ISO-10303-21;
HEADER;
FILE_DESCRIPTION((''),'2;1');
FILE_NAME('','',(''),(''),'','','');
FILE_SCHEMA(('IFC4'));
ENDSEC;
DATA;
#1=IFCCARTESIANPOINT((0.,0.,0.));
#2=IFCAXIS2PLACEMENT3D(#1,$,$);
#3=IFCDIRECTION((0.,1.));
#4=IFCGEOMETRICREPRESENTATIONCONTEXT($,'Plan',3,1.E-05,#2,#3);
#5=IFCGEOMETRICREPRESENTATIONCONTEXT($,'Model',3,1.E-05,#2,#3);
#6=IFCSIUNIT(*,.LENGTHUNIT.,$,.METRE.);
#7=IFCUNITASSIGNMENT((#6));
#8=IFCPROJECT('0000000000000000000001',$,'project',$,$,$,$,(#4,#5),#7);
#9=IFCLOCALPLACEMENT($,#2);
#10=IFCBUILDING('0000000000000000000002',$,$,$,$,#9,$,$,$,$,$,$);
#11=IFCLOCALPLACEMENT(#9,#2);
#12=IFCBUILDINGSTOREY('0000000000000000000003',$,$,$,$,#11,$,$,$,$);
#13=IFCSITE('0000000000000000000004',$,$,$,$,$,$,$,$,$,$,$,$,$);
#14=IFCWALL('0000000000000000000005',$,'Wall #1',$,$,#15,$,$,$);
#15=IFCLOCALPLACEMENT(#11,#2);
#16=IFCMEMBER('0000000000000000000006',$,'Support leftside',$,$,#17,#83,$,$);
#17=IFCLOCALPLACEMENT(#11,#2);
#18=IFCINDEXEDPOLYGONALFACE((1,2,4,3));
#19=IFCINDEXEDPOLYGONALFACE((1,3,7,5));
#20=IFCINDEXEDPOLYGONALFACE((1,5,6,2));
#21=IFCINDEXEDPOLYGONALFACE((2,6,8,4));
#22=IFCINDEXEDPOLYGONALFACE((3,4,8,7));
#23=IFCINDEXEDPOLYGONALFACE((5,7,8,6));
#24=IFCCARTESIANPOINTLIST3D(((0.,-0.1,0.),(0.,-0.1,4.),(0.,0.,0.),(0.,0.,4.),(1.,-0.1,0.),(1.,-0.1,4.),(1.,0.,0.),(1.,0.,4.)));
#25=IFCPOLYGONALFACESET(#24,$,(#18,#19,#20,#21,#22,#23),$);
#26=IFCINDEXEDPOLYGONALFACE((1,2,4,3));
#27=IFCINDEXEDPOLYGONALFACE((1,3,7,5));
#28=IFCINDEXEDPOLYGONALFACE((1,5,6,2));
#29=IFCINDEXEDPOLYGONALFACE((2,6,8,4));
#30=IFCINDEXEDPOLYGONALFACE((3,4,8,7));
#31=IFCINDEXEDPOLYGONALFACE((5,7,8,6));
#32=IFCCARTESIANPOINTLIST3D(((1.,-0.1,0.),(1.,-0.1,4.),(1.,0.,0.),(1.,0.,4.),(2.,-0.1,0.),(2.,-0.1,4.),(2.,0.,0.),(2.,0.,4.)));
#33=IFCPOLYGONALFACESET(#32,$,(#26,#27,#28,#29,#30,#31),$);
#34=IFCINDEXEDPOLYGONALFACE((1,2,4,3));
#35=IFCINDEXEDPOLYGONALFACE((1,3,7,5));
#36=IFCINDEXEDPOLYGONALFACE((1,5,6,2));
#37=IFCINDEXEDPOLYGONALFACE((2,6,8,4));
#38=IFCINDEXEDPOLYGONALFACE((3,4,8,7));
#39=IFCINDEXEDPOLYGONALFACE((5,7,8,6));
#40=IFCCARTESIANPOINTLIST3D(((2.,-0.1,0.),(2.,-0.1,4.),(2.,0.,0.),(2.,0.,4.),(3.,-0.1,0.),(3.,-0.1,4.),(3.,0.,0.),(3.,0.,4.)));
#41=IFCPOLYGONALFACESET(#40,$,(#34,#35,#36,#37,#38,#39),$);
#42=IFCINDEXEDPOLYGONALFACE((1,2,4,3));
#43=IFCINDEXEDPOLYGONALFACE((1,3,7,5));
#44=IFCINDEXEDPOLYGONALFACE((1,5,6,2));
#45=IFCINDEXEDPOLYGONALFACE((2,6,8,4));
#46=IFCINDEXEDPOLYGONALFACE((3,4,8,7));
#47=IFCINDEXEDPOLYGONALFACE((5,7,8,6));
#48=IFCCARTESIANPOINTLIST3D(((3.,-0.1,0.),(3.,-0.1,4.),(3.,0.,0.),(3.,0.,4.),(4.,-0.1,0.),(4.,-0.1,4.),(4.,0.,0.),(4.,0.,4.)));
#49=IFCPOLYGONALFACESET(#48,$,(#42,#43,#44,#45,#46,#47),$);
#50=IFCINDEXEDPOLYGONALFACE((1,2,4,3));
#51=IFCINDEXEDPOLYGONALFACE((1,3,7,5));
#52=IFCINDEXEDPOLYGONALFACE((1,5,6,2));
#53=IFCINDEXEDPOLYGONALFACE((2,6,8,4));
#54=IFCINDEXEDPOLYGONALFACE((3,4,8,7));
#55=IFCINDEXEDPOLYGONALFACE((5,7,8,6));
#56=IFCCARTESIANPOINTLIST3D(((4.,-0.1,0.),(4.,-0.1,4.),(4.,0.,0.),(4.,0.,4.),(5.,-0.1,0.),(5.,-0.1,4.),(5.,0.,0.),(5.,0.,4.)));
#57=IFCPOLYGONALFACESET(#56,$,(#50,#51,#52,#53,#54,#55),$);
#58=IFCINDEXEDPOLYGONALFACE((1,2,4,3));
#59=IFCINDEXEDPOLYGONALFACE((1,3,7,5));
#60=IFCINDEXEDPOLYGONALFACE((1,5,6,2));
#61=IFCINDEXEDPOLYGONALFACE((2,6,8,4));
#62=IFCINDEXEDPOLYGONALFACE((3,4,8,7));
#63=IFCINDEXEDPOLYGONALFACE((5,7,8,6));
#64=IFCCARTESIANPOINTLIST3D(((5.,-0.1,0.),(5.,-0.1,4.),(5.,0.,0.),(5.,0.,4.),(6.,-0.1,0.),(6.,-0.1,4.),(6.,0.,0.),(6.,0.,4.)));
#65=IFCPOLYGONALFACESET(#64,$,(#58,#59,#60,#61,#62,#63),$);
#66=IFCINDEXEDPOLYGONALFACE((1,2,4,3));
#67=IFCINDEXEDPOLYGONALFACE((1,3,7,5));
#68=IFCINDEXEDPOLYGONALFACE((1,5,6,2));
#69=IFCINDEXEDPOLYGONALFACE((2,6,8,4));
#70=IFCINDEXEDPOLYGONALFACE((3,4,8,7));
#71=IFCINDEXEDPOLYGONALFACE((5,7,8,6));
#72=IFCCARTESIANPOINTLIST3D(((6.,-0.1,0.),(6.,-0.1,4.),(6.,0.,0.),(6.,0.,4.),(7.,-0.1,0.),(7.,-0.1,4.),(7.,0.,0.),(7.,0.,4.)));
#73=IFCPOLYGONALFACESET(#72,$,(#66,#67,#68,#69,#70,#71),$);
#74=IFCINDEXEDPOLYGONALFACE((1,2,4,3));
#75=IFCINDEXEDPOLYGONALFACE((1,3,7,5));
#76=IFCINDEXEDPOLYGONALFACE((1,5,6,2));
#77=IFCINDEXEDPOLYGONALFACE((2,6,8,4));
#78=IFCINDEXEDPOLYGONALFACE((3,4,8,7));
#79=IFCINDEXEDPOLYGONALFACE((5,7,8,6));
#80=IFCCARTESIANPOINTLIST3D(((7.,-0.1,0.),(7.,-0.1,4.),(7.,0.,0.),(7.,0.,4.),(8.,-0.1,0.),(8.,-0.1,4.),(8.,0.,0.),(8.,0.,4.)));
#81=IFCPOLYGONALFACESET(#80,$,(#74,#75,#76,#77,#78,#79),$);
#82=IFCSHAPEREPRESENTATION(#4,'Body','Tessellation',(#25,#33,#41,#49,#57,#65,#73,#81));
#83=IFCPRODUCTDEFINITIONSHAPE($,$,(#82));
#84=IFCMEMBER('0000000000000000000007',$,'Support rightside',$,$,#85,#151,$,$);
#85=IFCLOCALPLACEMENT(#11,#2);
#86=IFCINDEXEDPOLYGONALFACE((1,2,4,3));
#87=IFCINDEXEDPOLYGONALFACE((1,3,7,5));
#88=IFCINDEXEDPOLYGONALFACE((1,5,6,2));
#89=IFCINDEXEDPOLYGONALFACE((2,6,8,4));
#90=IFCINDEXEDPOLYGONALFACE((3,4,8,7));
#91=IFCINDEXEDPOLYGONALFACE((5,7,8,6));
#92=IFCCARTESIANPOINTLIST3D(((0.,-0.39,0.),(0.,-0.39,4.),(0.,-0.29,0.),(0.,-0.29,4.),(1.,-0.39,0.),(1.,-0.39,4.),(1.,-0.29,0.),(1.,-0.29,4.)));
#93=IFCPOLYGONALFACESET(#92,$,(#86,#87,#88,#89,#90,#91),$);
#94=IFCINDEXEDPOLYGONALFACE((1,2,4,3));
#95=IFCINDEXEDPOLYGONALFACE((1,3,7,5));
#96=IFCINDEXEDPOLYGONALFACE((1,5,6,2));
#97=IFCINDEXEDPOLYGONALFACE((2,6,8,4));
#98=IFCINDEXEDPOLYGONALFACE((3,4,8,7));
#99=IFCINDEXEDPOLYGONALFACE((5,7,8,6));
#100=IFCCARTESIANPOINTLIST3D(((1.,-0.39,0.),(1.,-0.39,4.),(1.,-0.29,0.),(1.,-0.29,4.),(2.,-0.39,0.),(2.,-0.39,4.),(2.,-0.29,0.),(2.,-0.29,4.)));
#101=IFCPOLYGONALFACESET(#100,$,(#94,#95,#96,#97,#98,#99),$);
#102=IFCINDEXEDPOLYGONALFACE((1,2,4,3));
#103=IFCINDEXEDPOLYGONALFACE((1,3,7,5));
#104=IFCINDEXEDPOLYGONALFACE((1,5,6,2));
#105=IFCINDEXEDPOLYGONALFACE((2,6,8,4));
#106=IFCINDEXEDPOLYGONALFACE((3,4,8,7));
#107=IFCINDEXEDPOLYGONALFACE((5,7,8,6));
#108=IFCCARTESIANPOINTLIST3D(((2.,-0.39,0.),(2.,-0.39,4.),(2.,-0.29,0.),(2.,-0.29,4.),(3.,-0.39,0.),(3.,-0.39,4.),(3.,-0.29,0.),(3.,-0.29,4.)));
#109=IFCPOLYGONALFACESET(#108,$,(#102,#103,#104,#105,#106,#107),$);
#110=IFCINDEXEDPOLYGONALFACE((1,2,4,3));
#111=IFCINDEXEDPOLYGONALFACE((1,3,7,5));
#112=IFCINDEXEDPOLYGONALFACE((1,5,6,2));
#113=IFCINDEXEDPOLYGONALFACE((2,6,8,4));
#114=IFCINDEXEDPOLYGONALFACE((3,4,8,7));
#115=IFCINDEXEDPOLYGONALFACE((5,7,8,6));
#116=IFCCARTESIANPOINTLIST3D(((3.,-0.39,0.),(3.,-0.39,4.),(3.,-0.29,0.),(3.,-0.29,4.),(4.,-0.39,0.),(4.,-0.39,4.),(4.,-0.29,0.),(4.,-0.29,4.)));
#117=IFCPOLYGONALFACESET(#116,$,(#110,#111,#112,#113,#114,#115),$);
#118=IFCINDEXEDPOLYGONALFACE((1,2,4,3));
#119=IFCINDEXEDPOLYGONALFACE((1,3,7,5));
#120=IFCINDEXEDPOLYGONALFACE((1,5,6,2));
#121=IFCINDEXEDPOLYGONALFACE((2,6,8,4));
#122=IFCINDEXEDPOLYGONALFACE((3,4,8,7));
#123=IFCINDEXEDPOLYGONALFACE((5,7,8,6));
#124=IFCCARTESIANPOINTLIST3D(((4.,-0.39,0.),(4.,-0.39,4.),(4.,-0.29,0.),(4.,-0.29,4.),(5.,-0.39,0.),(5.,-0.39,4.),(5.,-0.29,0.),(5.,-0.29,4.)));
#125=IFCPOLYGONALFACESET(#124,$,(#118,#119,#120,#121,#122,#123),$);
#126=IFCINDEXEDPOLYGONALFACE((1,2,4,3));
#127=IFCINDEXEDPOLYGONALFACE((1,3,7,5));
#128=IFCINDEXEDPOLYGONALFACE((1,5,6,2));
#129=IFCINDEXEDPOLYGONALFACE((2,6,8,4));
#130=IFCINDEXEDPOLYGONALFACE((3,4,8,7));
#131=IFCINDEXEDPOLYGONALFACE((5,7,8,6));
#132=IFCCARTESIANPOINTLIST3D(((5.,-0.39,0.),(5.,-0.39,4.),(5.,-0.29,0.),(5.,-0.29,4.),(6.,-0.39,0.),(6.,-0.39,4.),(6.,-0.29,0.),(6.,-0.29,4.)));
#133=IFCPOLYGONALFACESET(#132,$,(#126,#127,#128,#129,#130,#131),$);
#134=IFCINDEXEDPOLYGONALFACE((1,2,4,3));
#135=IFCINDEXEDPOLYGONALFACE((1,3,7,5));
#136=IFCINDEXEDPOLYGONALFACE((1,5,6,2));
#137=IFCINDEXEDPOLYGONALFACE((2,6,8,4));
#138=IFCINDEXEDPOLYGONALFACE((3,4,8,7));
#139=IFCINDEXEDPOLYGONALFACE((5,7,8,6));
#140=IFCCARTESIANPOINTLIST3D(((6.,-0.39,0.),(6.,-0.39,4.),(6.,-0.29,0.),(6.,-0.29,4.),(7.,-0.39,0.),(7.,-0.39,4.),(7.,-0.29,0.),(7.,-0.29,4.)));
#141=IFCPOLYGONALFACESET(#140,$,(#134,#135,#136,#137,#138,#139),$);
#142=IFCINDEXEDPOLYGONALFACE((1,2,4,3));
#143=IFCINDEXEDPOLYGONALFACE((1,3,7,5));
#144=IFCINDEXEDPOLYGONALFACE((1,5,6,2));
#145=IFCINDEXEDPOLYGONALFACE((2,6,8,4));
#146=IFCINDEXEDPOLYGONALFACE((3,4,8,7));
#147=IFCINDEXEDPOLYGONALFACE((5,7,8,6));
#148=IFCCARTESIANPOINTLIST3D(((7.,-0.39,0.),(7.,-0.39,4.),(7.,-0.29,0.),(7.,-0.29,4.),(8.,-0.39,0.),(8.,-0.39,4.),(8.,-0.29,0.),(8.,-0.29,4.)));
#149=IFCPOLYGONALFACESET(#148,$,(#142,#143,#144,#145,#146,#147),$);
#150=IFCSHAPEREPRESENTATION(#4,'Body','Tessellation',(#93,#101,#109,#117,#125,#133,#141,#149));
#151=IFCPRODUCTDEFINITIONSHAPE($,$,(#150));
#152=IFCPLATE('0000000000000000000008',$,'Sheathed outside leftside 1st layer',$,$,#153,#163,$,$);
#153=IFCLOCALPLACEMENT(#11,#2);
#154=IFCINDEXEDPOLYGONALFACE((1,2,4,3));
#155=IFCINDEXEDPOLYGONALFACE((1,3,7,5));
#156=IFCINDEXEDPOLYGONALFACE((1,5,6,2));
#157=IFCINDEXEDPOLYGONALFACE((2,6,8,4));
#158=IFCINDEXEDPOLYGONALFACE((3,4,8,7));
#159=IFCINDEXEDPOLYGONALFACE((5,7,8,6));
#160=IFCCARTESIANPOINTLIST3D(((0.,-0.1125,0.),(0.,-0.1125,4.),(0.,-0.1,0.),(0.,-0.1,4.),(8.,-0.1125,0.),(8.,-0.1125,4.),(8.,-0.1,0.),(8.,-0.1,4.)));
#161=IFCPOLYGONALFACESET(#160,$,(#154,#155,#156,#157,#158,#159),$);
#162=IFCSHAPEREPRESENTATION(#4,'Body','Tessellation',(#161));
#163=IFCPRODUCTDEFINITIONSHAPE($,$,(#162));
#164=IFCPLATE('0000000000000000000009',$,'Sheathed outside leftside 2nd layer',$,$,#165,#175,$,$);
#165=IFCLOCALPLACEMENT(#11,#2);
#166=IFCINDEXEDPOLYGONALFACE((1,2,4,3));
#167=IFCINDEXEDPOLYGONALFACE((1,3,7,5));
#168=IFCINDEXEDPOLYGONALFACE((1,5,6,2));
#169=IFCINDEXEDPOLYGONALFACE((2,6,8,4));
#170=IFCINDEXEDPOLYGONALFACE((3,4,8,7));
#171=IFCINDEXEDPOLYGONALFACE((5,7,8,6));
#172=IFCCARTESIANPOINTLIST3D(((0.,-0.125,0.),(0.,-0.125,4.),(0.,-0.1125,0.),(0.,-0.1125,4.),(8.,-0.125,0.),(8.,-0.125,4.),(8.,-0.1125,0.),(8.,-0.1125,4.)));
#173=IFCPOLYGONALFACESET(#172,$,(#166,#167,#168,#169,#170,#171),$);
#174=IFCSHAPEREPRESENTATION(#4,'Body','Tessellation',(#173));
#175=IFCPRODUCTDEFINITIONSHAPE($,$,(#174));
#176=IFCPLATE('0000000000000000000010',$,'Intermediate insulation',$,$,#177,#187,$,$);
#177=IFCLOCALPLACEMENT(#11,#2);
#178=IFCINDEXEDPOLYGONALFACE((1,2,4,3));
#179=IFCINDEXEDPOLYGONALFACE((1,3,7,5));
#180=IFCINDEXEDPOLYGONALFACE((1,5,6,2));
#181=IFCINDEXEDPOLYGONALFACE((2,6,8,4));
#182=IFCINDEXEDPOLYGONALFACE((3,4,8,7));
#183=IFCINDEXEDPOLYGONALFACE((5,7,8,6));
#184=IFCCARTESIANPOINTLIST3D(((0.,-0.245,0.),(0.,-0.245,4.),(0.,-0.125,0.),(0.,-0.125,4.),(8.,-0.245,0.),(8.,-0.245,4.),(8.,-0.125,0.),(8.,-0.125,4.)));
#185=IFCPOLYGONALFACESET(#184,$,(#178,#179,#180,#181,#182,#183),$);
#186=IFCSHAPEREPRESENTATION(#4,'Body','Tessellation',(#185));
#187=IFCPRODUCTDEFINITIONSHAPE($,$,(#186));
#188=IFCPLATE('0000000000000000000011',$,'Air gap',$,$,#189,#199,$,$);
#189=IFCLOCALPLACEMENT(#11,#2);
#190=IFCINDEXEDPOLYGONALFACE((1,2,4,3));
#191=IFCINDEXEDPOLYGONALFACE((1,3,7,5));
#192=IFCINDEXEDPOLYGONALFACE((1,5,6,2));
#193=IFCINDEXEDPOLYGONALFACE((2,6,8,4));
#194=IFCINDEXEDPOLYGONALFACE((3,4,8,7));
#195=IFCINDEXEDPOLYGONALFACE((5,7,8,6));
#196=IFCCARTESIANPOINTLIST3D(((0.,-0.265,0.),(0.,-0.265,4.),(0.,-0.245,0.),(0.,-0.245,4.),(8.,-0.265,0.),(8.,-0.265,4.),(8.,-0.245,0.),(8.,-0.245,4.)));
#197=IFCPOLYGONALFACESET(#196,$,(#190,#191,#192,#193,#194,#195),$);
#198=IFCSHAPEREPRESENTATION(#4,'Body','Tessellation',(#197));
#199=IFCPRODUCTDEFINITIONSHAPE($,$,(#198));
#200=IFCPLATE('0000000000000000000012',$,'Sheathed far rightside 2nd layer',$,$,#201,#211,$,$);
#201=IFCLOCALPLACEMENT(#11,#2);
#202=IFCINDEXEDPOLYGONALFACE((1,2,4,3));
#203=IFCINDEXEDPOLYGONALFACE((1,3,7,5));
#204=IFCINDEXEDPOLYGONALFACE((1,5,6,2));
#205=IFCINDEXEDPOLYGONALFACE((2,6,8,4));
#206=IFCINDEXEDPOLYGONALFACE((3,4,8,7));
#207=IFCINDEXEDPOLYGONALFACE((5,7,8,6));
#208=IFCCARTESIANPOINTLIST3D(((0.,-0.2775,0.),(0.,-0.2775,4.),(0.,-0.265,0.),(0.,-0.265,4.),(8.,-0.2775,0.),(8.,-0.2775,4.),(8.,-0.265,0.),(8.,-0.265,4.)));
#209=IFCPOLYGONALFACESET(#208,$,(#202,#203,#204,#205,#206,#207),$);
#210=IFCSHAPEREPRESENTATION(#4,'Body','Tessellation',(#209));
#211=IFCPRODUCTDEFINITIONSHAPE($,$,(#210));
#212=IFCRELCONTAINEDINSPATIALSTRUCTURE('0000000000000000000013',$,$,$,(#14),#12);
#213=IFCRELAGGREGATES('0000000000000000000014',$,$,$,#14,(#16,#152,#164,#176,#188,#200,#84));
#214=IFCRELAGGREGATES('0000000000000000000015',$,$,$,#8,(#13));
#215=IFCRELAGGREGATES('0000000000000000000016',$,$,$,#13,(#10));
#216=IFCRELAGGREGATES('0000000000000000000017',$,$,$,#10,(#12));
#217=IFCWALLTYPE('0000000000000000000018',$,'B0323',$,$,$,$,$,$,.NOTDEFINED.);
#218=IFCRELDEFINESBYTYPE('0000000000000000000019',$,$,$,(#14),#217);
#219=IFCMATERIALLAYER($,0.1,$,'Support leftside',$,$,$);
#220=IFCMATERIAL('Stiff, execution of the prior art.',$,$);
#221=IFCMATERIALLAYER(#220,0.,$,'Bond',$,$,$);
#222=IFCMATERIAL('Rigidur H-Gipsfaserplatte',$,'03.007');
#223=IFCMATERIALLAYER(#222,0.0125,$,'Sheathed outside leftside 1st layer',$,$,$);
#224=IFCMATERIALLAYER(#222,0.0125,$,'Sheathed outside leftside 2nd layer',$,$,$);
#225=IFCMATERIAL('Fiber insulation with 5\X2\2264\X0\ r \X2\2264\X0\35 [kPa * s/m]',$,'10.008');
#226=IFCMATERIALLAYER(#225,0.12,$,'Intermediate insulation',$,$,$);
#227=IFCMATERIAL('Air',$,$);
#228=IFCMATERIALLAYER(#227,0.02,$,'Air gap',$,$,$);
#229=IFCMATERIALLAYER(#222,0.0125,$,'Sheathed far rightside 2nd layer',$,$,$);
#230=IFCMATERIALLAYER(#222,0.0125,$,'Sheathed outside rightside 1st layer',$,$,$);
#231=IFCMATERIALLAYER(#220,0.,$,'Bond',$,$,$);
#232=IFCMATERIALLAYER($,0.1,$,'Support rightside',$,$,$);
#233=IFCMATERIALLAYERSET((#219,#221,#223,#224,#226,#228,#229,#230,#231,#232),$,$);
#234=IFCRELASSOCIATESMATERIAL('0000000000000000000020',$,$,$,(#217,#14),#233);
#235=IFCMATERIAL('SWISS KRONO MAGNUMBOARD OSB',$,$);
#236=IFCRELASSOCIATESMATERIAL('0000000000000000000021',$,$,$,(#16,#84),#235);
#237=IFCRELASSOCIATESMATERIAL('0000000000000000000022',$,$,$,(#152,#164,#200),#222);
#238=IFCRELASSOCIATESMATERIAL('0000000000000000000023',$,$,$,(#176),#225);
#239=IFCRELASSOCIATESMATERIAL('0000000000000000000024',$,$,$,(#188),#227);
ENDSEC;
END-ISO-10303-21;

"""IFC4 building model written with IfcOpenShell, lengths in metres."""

from ifc_helpers import new_model, si_unit, direction, frame, frame_2d, origin, place, context, project, spatial, rectangle, extrude, material, layer, layer_set, type_object, element, aggregate, save


model = new_model("IFC4")

# Units and contexts
plan_context = context("Plan", 3, precision=1e-05, world=origin(), true_north=direction((0.0, 1.0)))
model_context = context("Model", 3, precision=1e-05, world=origin(), true_north=direction((0.0, 1.0)))
ifc_project = project(units=[si_unit("LENGTHUNIT", "METRE")], contexts=[plan_context, model_context])

# Site, building, storey
site = spatial("IfcSite", under=ifc_project)
building_placement = place(None, origin())
building = spatial("IfcBuilding", under=site, at=building_placement)
storey_placement = place(building_placement, origin())
storey = spatial("IfcBuildingStorey", under=building, at=storey_placement)

# Wall, members, plates
ifc_layer_1 = layer(None, 0.1, Name="Support leftside")
ifc_material_1 = material(Name="Stiff, execution of the prior art.")
ifc_layer_2 = layer(ifc_material_1, 0.0, Name="Bond")
ifc_material_2 = material(Name="Rigidur H-Gipsfaserplatte", Category="03.007")
ifc_layer_3 = layer(ifc_material_2, 0.0125, Name="Sheathed outside leftside 1st layer")
ifc_layer_4 = layer(ifc_material_2, 0.0125, Name="Sheathed outside leftside 2nd layer")
ifc_material_3 = material(Name="Fiber insulation with 5≤ r ≤35 [kPa * s/m]", Category="10.008")
ifc_layer_5 = layer(ifc_material_3, 0.12, Name="Intermediate insulation")
ifc_material_4 = material(Name="Air")
ifc_layer_6 = layer(ifc_material_4, 0.02, Name="Air gap")
ifc_layer_7 = layer(ifc_material_2, 0.0125, Name="Sheathed far rightside 2nd layer")
ifc_layer_8 = layer(ifc_material_2, 0.0125, Name="Sheathed outside rightside 1st layer")
ifc_layer_9 = layer(ifc_material_1, 0.0, Name="Bond")
ifc_layer_10 = layer(None, 0.1, Name="Support rightside")
ifc_layer_set = layer_set([ifc_layer_1, ifc_layer_2, ifc_layer_3, ifc_layer_4, ifc_layer_5, ifc_layer_6, ifc_layer_7, ifc_layer_8, ifc_layer_9, ifc_layer_10])
wall_type = type_object("IfcWallType", Name="B0323", PredefinedType="NOTDEFINED", material=ifc_layer_set)
wall_placement = place(None, frame((0.0, 0.0, 0.0), z_axis=(0.0, -1.0, 0.0), x_axis=(1.0, 0.0, 0.0)))
wall = element("IfcWall", 1, at=wall_placement, inside=storey, type_object=wall_type, material=ifc_layer_set, Name="Wall #1")
ifc_material_5 = material(Name="SWISS KRONO MAGNUMBOARD OSB")
member_1_placement = place(wall_placement, origin())
member_1 = element("IfcMember", 2, at=member_1_placement, material=ifc_material_5, Name="Support leftside", context=plan_context, shape_type="SweptSolid", body=[
    extrude(rectangle(XDim=1.0, YDim=0.1, at=frame_2d((0.5, 0.05), x_axis=(1.0, 0.0))), frame((0.0, 4.0, 0.0), z_axis=(0.0, -1.0, 0.0), x_axis=(1.0, 0.0, 0.0)), (0.0, 0.0, 1.0), 4.0),
    extrude(rectangle(XDim=1.0, YDim=0.1, at=frame_2d((0.5, 0.05), x_axis=(1.0, 0.0))), frame((1.0, 4.0, 0.0), z_axis=(0.0, -1.0, 0.0), x_axis=(1.0, 0.0, 0.0)), (0.0, 0.0, 1.0), 4.0),
    extrude(rectangle(XDim=1.0, YDim=0.1, at=frame_2d((0.5, 0.05), x_axis=(1.0, 0.0))), frame((2.0, 4.0, 0.0), z_axis=(0.0, -1.0, 0.0), x_axis=(1.0, 0.0, 0.0)), (0.0, 0.0, 1.0), 4.0),
    extrude(rectangle(XDim=1.0, YDim=0.1, at=frame_2d((0.5, 0.05), x_axis=(1.0, 0.0))), frame((3.0, 4.0, 0.0), z_axis=(0.0, -1.0, 0.0), x_axis=(1.0, 0.0, 0.0)), (0.0, 0.0, 1.0), 4.0),
    extrude(rectangle(XDim=1.0, YDim=0.1, at=frame_2d((0.5, 0.05), x_axis=(1.0, 0.0))), frame((4.0, 4.0, 0.0), z_axis=(0.0, -1.0, 0.0), x_axis=(1.0, 0.0, 0.0)), (0.0, 0.0, 1.0), 4.0),
    extrude(rectangle(XDim=1.0, YDim=0.1, at=frame_2d((0.5, 0.05), x_axis=(1.0, 0.0))), frame((5.0, 4.0, 0.0), z_axis=(0.0, -1.0, 0.0), x_axis=(1.0, 0.0, 0.0)), (0.0, 0.0, 1.0), 4.0),
    extrude(rectangle(XDim=1.0, YDim=0.1, at=frame_2d((0.5, 0.05), x_axis=(1.0, 0.0))), frame((6.0, 4.0, 0.0), z_axis=(0.0, -1.0, 0.0), x_axis=(1.0, 0.0, 0.0)), (0.0, 0.0, 1.0), 4.0),
    extrude(rectangle(XDim=1.0, YDim=0.1, at=frame_2d((0.5, 0.05), x_axis=(1.0, 0.0))), frame((7.0, 4.0, 0.0), z_axis=(0.0, -1.0, 0.0), x_axis=(1.0, 0.0, 0.0)), (0.0, 0.0, 1.0), 4.0),
])
member_2_placement = place(wall_placement, origin())
member_2 = element("IfcMember", 3, at=member_2_placement, material=ifc_material_5, Name="Support rightside", context=plan_context, shape_type="SweptSolid", body=[
    extrude(rectangle(XDim=1.0, YDim=0.1, at=frame_2d((0.5, 0.05), x_axis=(1.0, 0.0))), frame((0.0, 4.0, 0.29), z_axis=(0.0, -1.0, 0.0), x_axis=(1.0, 0.0, 0.0)), (0.0, 0.0, 1.0), 4.0),
    extrude(rectangle(XDim=1.0, YDim=0.1, at=frame_2d((0.5, 0.05), x_axis=(1.0, 0.0))), frame((1.0, 4.0, 0.29), z_axis=(0.0, -1.0, 0.0), x_axis=(1.0, 0.0, 0.0)), (0.0, 0.0, 1.0), 4.0),
    extrude(rectangle(XDim=1.0, YDim=0.1, at=frame_2d((0.5, 0.05), x_axis=(1.0, 0.0))), frame((2.0, 4.0, 0.29), z_axis=(0.0, -1.0, 0.0), x_axis=(1.0, 0.0, 0.0)), (0.0, 0.0, 1.0), 4.0),
    extrude(rectangle(XDim=1.0, YDim=0.1, at=frame_2d((0.5, 0.05), x_axis=(1.0, 0.0))), frame((3.0, 4.0, 0.29), z_axis=(0.0, -1.0, 0.0), x_axis=(1.0, 0.0, 0.0)), (0.0, 0.0, 1.0), 4.0),
    extrude(rectangle(XDim=1.0, YDim=0.1, at=frame_2d((0.5, 0.05), x_axis=(1.0, 0.0))), frame((4.0, 4.0, 0.29), z_axis=(0.0, -1.0, 0.0), x_axis=(1.0, 0.0, 0.0)), (0.0, 0.0, 1.0), 4.0),
    extrude(rectangle(XDim=1.0, YDim=0.1, at=frame_2d((0.5, 0.05), x_axis=(1.0, 0.0))), frame((5.0, 4.0, 0.29), z_axis=(0.0, -1.0, 0.0), x_axis=(1.0, 0.0, 0.0)), (0.0, 0.0, 1.0), 4.0),
    extrude(rectangle(XDim=1.0, YDim=0.1, at=frame_2d((0.5, 0.05), x_axis=(1.0, 0.0))), frame((6.0, 4.0, 0.29), z_axis=(0.0, -1.0, 0.0), x_axis=(1.0, 0.0, 0.0)), (0.0, 0.0, 1.0), 4.0),
    extrude(rectangle(XDim=1.0, YDim=0.1, at=frame_2d((0.5, 0.05), x_axis=(1.0, 0.0))), frame((7.0, 4.0, 0.29), z_axis=(0.0, -1.0, 0.0), x_axis=(1.0, 0.0, 0.0)), (0.0, 0.0, 1.0), 4.0),
])
plate_1_placement = place(wall_placement, origin())
plate_1 = element("IfcPlate", 4, at=plate_1_placement, material=ifc_material_2, Name="Sheathed outside leftside 1st layer", context=plan_context, shape_type="SweptSolid", body=[
    extrude(rectangle(XDim=8.0, YDim=4.0, at=frame_2d((4.0, 2.0), x_axis=(1.0, 0.0))), frame((0.0, 0.0, 0.1), z_axis=(0.0, 0.0, 1.0), x_axis=(1.0, 0.0, 0.0)), (0.0, 0.0, 1.0), 0.0125),
])
plate_2_placement = place(wall_placement, origin())
plate_2 = element("IfcPlate", 5, at=plate_2_placement, material=ifc_material_2, Name="Sheathed outside leftside 2nd layer", context=plan_context, shape_type="SweptSolid", body=[
    extrude(rectangle(XDim=8.0, YDim=4.0, at=frame_2d((4.0, 2.0), x_axis=(1.0, 0.0))), frame((0.0, 0.0, 0.1125), z_axis=(0.0, 0.0, 1.0), x_axis=(1.0, 0.0, 0.0)), (0.0, 0.0, 1.0), 0.0125),
])
plate_3_placement = place(wall_placement, origin())
plate_3 = element("IfcPlate", 6, at=plate_3_placement, material=ifc_material_3, Name="Intermediate insulation", context=plan_context, shape_type="SweptSolid", body=[
    extrude(rectangle(XDim=8.0, YDim=4.0, at=frame_2d((4.0, 2.0), x_axis=(1.0, 0.0))), frame((0.0, 0.0, 0.125), z_axis=(0.0, 0.0, 1.0), x_axis=(1.0, 0.0, 0.0)), (0.0, 0.0, 1.0), 0.12),
])
plate_4_placement = place(wall_placement, origin())
plate_4 = element("IfcPlate", 7, at=plate_4_placement, material=ifc_material_4, Name="Air gap", context=plan_context, shape_type="SweptSolid", body=[
    extrude(rectangle(XDim=8.0, YDim=4.0, at=frame_2d((4.0, 2.0), x_axis=(1.0, 0.0))), frame((0.0, 0.0, 0.245), z_axis=(0.0, 0.0, 1.0), x_axis=(1.0, 0.0, 0.0)), (0.0, 0.0, 1.0), 0.02),
])
plate_5_placement = place(wall_placement, origin())
plate_5 = element("IfcPlate", 8, at=plate_5_placement, material=ifc_material_2, Name="Sheathed far rightside 2nd layer", context=plan_context, shape_type="SweptSolid", body=[
    extrude(rectangle(XDim=8.0, YDim=4.0, at=frame_2d((4.0, 2.0), x_axis=(1.0, 0.0))), frame((0.0, 0.0, 0.265), z_axis=(0.0, 0.0, 1.0), x_axis=(1.0, 0.0, 0.0)), (0.0, 0.0, 1.0), 0.0125),
])
aggregate(wall, [member_1, plate_1, plate_2, plate_3, plate_4, plate_5, member_2])

save(model, "model.ifc")
